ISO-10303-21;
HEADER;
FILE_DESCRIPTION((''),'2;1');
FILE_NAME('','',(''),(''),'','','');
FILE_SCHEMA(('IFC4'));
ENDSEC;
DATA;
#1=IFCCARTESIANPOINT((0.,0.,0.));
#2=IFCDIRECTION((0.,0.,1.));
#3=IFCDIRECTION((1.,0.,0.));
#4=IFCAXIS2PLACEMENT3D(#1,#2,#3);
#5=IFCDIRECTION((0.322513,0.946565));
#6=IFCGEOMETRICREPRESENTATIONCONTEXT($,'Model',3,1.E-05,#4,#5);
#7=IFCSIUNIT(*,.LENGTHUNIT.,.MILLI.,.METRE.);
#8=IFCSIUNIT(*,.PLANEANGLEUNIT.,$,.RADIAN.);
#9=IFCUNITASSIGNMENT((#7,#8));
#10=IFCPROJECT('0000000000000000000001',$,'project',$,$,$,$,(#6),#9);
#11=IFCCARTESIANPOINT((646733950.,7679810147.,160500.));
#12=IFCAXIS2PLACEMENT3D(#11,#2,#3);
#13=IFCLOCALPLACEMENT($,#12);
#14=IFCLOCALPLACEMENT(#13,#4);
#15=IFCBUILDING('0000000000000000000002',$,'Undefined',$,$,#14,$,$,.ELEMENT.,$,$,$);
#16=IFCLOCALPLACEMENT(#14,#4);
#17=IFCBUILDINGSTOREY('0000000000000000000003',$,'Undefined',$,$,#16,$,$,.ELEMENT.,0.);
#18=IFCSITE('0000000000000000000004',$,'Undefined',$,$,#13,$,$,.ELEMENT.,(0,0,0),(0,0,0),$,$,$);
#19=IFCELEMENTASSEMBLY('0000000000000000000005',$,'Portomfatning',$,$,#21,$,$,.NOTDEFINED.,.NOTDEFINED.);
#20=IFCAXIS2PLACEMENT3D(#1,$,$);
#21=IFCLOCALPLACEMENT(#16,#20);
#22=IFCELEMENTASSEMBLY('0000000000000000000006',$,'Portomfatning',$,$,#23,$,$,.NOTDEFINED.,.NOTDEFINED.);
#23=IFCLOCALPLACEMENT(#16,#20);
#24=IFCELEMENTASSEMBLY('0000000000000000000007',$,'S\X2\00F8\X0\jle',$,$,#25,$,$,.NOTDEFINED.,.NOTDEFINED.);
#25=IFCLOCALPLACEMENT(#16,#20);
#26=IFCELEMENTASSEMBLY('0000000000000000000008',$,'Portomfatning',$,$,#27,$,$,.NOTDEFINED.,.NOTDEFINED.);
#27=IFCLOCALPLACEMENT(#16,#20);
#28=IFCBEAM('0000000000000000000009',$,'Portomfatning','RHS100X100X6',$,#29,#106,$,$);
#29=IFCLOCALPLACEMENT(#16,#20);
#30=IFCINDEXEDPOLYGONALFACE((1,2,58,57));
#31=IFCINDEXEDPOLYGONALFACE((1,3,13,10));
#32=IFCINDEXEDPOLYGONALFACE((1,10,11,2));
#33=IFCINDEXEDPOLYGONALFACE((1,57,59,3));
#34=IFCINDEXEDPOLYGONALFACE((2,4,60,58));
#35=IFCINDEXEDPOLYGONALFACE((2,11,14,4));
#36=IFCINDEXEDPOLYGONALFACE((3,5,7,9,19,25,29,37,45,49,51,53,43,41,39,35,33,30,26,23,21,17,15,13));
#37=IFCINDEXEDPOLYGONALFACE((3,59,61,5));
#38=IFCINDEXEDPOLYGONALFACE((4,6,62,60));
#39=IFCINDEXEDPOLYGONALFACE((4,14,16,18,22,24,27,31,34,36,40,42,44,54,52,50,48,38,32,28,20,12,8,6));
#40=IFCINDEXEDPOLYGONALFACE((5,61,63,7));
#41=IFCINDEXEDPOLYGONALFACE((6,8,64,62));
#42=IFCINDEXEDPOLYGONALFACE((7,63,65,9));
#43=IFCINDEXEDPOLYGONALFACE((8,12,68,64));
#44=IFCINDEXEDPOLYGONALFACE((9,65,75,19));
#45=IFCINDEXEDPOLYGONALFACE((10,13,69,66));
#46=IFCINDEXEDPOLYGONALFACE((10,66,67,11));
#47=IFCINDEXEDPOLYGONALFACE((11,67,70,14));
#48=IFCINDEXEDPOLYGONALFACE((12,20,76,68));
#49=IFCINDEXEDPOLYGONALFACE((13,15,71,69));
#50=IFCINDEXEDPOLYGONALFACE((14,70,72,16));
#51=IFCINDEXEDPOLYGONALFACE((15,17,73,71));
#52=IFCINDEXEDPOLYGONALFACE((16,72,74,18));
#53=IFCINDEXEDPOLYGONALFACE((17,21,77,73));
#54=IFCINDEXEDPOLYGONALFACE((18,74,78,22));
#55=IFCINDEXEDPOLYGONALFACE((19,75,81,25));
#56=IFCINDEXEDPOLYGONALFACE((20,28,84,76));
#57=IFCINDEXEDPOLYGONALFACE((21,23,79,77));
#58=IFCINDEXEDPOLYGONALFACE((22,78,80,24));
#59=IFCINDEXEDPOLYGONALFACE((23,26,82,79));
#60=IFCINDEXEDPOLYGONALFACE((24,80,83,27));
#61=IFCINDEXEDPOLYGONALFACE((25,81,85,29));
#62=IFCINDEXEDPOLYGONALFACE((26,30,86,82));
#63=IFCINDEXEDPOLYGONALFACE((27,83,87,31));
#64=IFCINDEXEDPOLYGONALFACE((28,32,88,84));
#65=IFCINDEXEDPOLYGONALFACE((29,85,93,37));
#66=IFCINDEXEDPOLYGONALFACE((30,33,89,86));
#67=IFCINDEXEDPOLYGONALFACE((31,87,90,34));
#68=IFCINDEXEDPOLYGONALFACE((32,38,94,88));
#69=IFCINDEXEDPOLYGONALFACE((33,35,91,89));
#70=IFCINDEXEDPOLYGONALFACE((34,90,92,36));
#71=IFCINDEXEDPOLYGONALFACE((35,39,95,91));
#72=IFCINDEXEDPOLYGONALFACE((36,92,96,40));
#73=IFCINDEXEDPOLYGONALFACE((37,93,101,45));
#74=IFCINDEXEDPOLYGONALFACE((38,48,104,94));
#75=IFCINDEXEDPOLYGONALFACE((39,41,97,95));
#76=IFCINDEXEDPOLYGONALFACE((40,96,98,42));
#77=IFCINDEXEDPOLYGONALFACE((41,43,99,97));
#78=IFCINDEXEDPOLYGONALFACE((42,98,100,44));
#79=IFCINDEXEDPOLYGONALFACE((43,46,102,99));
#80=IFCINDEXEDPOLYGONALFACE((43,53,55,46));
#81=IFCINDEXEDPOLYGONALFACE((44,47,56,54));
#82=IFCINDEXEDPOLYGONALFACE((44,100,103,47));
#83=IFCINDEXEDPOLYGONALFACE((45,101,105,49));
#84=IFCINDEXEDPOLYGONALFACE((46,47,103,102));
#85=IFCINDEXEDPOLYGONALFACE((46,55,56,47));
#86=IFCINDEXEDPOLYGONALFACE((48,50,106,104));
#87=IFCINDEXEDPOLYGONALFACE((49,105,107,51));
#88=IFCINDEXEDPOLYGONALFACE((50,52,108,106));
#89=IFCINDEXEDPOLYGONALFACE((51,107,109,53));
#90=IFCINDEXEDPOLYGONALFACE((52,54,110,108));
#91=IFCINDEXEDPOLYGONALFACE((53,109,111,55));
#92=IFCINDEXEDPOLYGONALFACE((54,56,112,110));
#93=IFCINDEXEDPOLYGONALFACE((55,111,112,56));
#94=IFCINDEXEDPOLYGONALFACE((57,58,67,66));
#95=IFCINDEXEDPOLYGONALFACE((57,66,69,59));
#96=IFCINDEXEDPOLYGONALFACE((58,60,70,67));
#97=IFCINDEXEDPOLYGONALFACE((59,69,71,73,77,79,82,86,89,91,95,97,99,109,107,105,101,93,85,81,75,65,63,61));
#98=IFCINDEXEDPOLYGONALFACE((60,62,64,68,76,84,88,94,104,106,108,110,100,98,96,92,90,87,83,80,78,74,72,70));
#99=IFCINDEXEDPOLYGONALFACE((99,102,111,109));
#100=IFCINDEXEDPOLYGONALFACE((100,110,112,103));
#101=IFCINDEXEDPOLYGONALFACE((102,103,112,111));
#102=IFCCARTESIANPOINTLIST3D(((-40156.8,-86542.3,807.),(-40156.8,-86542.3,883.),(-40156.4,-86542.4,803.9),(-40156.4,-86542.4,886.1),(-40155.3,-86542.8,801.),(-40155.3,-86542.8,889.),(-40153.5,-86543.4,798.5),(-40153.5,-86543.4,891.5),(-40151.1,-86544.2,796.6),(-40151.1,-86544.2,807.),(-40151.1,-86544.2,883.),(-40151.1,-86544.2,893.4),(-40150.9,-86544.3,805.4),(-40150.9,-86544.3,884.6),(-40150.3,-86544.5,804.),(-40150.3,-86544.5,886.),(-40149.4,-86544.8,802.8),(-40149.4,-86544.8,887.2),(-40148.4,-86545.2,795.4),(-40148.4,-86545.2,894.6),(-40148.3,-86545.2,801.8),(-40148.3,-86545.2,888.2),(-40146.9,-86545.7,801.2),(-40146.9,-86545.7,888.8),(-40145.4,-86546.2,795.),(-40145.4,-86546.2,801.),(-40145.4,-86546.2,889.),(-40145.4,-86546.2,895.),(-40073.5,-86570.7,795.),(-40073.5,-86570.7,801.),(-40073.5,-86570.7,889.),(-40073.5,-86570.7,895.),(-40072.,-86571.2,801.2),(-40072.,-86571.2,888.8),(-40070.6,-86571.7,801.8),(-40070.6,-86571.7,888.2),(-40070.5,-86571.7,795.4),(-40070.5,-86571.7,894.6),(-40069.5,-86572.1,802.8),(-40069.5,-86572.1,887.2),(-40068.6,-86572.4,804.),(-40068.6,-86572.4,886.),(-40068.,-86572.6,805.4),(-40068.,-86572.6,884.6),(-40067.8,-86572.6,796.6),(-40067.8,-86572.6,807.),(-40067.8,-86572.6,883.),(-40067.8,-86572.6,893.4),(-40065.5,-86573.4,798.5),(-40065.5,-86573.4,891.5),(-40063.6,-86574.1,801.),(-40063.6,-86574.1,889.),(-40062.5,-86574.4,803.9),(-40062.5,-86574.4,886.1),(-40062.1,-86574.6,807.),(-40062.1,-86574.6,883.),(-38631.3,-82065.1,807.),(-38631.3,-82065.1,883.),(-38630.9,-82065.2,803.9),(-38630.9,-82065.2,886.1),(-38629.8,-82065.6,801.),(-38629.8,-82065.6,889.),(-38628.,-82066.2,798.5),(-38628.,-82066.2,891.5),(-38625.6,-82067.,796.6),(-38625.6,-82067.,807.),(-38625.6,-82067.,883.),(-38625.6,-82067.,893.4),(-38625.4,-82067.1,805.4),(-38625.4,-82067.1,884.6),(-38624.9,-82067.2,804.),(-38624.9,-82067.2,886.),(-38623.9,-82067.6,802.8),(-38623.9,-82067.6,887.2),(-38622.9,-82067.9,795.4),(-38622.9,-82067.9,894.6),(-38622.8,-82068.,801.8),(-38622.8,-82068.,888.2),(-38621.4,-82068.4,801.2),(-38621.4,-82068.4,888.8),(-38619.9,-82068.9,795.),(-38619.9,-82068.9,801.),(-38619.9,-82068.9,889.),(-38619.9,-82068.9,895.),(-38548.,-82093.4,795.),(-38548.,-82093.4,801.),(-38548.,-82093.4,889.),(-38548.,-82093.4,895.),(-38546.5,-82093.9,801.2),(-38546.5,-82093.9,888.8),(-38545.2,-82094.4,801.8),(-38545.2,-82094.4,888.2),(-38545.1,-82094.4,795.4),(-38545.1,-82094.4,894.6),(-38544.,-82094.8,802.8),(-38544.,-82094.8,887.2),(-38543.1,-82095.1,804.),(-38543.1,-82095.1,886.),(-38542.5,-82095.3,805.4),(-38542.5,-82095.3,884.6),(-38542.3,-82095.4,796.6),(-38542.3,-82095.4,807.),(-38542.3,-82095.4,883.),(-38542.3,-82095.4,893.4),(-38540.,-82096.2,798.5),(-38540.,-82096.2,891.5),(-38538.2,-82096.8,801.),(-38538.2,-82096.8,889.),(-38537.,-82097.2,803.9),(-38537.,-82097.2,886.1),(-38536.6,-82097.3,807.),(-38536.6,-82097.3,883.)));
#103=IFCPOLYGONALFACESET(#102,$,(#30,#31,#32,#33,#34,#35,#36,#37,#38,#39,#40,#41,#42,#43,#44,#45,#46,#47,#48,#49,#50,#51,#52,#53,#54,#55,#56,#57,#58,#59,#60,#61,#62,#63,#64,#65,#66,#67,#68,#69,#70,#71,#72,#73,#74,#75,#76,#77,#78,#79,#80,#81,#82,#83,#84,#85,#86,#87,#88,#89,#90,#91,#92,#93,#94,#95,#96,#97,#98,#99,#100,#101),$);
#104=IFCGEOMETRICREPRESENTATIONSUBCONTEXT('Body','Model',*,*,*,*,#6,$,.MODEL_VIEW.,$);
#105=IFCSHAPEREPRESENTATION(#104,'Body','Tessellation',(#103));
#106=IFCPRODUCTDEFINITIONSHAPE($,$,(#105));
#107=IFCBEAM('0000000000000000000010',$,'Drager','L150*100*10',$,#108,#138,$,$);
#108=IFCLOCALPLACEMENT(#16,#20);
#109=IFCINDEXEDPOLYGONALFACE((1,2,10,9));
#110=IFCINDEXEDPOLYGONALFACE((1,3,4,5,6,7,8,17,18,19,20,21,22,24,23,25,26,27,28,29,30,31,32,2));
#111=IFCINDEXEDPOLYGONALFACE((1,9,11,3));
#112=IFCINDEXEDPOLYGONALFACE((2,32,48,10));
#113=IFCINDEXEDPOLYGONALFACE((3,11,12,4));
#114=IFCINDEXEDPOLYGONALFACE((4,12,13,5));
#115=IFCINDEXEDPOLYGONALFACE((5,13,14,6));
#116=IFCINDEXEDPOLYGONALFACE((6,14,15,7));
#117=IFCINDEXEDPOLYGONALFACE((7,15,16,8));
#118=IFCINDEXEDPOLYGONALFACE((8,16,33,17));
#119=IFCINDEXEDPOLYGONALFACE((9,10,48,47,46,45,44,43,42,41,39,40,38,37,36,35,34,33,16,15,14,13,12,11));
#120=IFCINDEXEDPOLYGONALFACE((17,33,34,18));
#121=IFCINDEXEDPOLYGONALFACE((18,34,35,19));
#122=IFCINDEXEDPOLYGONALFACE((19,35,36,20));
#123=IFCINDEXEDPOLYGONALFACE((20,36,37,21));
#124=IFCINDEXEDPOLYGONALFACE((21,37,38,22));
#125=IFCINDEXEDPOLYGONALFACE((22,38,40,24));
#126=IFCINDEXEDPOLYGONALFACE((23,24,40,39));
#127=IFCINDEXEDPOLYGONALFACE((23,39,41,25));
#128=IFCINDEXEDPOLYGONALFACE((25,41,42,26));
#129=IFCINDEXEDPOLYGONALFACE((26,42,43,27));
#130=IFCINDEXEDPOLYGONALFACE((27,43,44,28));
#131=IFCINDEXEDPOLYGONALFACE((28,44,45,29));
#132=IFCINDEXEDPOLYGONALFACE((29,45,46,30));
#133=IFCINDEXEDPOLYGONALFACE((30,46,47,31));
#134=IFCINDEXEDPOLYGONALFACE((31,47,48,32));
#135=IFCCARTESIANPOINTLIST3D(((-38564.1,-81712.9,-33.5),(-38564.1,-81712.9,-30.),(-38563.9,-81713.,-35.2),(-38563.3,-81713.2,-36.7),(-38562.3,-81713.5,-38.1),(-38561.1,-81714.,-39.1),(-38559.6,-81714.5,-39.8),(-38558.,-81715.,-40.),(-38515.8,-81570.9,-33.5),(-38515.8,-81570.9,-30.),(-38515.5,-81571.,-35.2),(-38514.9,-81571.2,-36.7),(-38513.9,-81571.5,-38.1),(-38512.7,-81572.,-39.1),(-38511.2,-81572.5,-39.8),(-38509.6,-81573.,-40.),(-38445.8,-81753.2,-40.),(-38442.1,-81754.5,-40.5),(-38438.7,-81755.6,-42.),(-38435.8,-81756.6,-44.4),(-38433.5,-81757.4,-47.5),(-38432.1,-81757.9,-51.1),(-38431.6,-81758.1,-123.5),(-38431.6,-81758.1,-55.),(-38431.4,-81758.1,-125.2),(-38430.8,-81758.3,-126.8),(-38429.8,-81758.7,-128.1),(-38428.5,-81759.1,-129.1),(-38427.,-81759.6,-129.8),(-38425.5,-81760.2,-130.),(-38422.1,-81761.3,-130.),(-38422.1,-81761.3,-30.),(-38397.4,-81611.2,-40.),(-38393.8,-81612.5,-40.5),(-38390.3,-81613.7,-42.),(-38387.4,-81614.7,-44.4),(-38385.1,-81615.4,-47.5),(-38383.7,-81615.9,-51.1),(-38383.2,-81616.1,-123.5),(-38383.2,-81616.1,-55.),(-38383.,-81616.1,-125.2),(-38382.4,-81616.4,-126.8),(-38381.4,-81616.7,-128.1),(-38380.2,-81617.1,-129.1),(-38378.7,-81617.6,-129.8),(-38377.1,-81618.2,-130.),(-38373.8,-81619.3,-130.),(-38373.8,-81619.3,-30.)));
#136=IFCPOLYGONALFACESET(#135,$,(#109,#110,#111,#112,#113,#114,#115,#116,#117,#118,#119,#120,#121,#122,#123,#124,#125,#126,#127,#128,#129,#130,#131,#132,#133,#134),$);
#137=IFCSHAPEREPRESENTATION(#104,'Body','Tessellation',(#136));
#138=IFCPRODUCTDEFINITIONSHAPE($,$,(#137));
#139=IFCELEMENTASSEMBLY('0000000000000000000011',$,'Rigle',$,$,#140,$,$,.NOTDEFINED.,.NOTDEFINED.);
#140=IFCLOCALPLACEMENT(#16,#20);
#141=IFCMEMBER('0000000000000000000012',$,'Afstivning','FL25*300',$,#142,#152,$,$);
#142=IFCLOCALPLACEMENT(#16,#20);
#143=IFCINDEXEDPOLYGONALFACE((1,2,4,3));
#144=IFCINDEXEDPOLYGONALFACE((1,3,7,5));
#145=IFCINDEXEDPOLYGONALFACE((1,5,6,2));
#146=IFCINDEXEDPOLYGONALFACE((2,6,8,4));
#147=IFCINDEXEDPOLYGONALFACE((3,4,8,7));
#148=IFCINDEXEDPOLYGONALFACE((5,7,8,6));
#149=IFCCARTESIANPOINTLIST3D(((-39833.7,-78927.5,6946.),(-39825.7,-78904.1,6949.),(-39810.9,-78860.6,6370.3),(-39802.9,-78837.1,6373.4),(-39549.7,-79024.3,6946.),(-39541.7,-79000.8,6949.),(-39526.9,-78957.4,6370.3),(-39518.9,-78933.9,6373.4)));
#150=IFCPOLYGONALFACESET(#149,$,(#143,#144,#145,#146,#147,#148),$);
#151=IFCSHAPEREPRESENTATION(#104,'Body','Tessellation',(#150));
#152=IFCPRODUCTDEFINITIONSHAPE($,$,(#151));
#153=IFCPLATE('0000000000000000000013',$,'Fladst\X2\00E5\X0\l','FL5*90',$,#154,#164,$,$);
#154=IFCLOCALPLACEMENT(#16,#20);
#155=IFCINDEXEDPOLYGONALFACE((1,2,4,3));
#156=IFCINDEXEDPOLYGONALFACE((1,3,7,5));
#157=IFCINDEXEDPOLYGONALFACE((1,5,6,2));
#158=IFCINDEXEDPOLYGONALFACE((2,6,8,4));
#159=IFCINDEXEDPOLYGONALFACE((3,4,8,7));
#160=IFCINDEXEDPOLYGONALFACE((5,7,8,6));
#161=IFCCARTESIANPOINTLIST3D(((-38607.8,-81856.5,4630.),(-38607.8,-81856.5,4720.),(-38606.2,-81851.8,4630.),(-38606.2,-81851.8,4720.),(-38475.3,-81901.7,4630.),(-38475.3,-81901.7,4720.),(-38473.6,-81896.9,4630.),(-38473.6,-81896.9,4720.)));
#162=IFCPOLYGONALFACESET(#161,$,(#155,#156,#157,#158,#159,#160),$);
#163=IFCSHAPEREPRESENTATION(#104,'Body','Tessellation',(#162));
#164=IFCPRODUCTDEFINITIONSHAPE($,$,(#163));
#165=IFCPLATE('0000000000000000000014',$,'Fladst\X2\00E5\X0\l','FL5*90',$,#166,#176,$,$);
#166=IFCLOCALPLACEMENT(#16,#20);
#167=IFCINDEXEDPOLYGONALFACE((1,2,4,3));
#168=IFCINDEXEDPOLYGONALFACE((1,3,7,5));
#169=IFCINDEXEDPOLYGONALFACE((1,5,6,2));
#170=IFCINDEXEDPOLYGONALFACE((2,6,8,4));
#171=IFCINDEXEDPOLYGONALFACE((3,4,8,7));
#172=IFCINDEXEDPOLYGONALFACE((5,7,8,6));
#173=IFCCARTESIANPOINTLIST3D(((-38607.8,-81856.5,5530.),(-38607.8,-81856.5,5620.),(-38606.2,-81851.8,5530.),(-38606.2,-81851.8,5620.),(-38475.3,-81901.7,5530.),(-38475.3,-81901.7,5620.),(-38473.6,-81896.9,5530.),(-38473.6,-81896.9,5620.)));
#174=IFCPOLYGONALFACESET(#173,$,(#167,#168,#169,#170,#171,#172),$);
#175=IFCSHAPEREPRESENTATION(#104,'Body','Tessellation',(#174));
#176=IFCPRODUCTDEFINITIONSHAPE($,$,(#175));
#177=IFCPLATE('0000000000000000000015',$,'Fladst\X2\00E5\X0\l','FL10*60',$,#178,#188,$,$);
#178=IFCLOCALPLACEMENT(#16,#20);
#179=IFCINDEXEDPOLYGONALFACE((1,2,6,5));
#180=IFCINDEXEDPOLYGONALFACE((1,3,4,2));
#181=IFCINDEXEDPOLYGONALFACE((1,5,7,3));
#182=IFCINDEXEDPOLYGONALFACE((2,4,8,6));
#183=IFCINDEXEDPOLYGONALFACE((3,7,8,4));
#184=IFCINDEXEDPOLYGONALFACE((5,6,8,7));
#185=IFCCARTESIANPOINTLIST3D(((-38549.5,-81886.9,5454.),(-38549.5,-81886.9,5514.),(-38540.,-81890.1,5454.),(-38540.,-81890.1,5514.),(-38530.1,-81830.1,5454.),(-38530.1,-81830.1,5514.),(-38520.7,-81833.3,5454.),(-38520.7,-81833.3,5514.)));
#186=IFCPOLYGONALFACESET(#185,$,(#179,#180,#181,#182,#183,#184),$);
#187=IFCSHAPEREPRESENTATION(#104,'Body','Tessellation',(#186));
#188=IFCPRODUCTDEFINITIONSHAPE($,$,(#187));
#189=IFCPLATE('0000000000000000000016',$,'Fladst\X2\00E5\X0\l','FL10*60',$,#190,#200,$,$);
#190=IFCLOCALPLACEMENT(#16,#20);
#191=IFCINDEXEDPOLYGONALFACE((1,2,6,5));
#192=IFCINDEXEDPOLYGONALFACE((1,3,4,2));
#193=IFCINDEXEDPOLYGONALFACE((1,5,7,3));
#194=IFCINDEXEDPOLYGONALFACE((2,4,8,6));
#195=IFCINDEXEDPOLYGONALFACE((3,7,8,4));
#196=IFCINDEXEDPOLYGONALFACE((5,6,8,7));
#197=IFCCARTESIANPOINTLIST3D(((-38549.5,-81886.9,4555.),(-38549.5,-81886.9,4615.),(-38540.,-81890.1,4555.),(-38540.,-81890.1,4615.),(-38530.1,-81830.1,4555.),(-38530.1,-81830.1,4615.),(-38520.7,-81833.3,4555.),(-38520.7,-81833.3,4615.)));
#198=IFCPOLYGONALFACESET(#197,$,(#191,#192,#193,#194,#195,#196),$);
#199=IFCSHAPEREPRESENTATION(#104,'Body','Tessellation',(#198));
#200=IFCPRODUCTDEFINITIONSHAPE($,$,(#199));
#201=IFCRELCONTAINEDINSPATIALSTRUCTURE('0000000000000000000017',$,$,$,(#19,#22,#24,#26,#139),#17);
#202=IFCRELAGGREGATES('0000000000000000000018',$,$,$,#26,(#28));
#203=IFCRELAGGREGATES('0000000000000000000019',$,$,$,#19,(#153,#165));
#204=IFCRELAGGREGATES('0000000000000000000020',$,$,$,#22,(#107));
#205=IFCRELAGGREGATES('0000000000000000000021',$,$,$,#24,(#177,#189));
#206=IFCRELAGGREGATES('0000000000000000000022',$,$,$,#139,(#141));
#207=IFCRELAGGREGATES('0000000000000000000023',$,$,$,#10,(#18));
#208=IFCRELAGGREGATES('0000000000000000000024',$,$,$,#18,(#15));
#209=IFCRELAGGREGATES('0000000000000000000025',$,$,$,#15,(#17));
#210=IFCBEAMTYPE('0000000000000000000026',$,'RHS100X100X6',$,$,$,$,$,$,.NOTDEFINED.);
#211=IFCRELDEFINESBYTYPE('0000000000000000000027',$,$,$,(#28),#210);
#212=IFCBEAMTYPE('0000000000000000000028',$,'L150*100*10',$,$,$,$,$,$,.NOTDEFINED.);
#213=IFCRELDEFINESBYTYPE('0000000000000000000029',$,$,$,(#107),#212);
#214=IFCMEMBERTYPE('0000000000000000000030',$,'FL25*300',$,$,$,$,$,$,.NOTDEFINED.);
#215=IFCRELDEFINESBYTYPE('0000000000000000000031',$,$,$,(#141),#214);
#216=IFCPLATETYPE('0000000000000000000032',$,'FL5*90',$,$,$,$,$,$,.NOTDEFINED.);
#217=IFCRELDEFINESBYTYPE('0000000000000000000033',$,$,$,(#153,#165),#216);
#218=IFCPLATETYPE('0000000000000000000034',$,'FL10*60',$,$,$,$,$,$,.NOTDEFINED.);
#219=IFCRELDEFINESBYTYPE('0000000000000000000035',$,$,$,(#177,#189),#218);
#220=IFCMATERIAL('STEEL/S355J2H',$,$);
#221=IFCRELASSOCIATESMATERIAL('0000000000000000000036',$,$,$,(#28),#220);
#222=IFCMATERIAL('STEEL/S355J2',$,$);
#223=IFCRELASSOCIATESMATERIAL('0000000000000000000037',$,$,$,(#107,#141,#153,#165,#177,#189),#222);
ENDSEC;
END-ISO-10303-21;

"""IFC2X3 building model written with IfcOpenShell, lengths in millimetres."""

from ifc_helpers import new_model, si_unit, direction, frame, origin_with_axes, origin_2d_with_axis, place, context, subcontext, project, spatial, polyline, rectangle, hollow_rectangle, l_section, outline, extrude, clip, halfspace, material, type_object, element, aggregate, save


model = new_model("IFC2X3")

# Units and contexts
model_context = context("Model", 3, precision=1e-05, world=origin_with_axes(), true_north=direction((0.322513, 0.946565)))
body_context = subcontext(model_context, "Body", "Model", "MODEL_VIEW")
ifc_project = project(units=[si_unit("LENGTHUNIT", "METRE", prefix="MILLI"), si_unit("PLANEANGLEUNIT", "RADIAN")], contexts=[model_context])

# Site, building, storey
site_placement = place(None, frame((646733950.0, 7679810147.0, 160500.0), z_axis=(0.0, 0.0, 1.0), x_axis=(1.0, 0.0, 0.0)))
site = spatial("IfcSite", under=ifc_project, at=site_placement, Name="Undefined", CompositionType="ELEMENT", RefLatitude=(0, 0, 0), RefLongitude=(0, 0, 0))
building_placement = place(site_placement, origin_with_axes())
building = spatial("IfcBuilding", under=site, at=building_placement, Name="Undefined", CompositionType="ELEMENT")
storey_placement = place(building_placement, origin_with_axes())
storey = spatial("IfcBuildingStorey", under=building, at=storey_placement, Name="Undefined", CompositionType="ELEMENT", Elevation=0.0)

# Element assembly
assembly_1_placement = place(storey_placement, origin_with_axes())
assembly_1 = element("IfcElementAssembly", 1, at=assembly_1_placement, inside=storey, Name="Portomfatning", AssemblyPlace="NOTDEFINED", PredefinedType="NOTDEFINED")
ifc_material_1 = material(Name="STEEL/S355J2H")

# Element assemblies
assembly_2_placement = place(storey_placement, origin_with_axes())
assembly_2 = element("IfcElementAssembly", 2, at=assembly_2_placement, inside=storey, Name="Portomfatning", AssemblyPlace="NOTDEFINED", PredefinedType="NOTDEFINED")
assembly_3_placement = place(storey_placement, origin_with_axes())
assembly_3 = element("IfcElementAssembly", 3, at=assembly_3_placement, inside=storey, Name="Søjle", AssemblyPlace="NOTDEFINED", PredefinedType="NOTDEFINED")

# Element assembly, beam
beam_type_1 = type_object("IfcBeamType", Name="RHS100X100X6", PredefinedType="NOTDEFINED")
assembly_4_placement = place(storey_placement, origin_with_axes())
assembly_4 = element("IfcElementAssembly", 4, at=assembly_4_placement, inside=storey, Name="Portomfatning", AssemblyPlace="NOTDEFINED", PredefinedType="NOTDEFINED")
beam_1_placement = place(assembly_4_placement, frame((-38579.1, -82067.0, 845.0), z_axis=(0.946565, -0.322513, 0.0), x_axis=(-0.322513, -0.946565, 0.0)))
beam_1 = element("IfcBeam", 5, at=beam_1_placement, type_object=beam_type_1, material=ifc_material_1, Name="Portomfatning", Description="RHS100X100X6", context=body_context, shape_type="Clipping", body=[
    clip(clip(extrude(hollow_rectangle(XDim=100.0, YDim=100.0, WallThickness=6.0, InnerFilletRadius=6.0, OuterFilletRadius=12.0, at=origin_2d_with_axis()), frame((4806.7, 0.0, 0.0), z_axis=(-1.0, 0.0, 0.0), x_axis=(0.0, -1.0, 0.0)), (0.0, 0.0, 1.0), 4853.4), halfspace(frame((4745.0, -50.0, -50.0), z_axis=(-1.0, 0.0, 0.000185), x_axis=(0.0, 1.0, 0.0)), True)), halfspace(frame((15.0, 50.0, -50.0), z_axis=(1.0, 0.0, 0.000185), x_axis=(0.0, -1.0, 0.0)), True)),
])
aggregate(assembly_4, [beam_1])

# Beam
ifc_material_2 = material(Name="STEEL/S355J2")
beam_type_2 = type_object("IfcBeamType", Name="L150*100*10", PredefinedType="NOTDEFINED")
beam_2_placement = place(assembly_2_placement, frame((-38444.8, -81595.1, -80.0), z_axis=(-0.946565, 0.322513, 0.0), x_axis=(-0.322513, -0.946565, 0.0)))
beam_2 = element("IfcBeam", 6, at=beam_2_placement, type_object=beam_type_2, material=ifc_material_2, Name="Drager", Description="L150*100*10", context=body_context, shape_type="SweptSolid", body=[
    extrude(l_section(Depth=150.0, Width=100.0, Thickness=10.0, FilletRadius=15.0, EdgeRadius=6.5, at=origin_2d_with_axis()), frame((150.0, 0.0, 0.0), z_axis=(-1.0, 0.0, 0.0), x_axis=(0.0, -1.0, 0.0)), (0.0, 0.0, 1.0), 150.0),
])

# Element assembly, member
assembly_5_placement = place(storey_placement, origin_with_axes())
assembly_5 = element("IfcElementAssembly", 7, at=assembly_5_placement, inside=storey, Name="Rigle", AssemblyPlace="NOTDEFINED", PredefinedType="NOTDEFINED")
member_type = type_object("IfcMemberType", Name="FL25*300", PredefinedType="NOTDEFINED")
member_placement = place(assembly_5_placement, frame((-39687.7, -78964.2, 6947.5), z_axis=(0.946565, -0.322513, 0.0), x_axis=(0.039304, 0.115357, -0.992546)))
member = element("IfcMember", 8, at=member_placement, type_object=member_type, material=ifc_material_2, Name="Afstivning", Description="FL25*300", context=body_context, shape_type="SweptSolid", body=[
    extrude(rectangle(XDim=25.0, YDim=300.0, at=origin_2d_with_axis()), frame((580.0, 0.0, 0.0), z_axis=(-1.0, 0.0, 0.0), x_axis=(0.0, -1.0, 0.0)), (0.0, 0.0, 1.0), 580.0),
])

# Plates
plate_type_1 = type_object("IfcPlateType", Name="FL5*90", PredefinedType="NOTDEFINED")
plate_1_placement = place(assembly_1_placement, frame((-38474.5, -81899.3, 4720.0), z_axis=(0.322626, 0.946527, 0.0), x_axis=(0.0, 0.0, -1.0)))
plate_1 = element("IfcPlate", 9, at=plate_1_placement, type_object=plate_type_1, material=ifc_material_2, Name="Fladstål", Description="FL5*90", context=body_context, shape_type="SweptSolid", body=[
    extrude(outline(polyline([(0.0, 0.0), (90.0, 0.0), (90.0, 140.0), (0.0, 140.0), (0.0, 0.0)])), frame((0.0, 0.0, -2.5), z_axis=(0.0, 0.0, 1.0), x_axis=(1.0, 0.0, 0.0)), (0.0, 0.0, 1.0), 5.0),
])
plate_2_placement = place(assembly_1_placement, frame((-38474.5, -81899.3, 5620.0), z_axis=(0.322626, 0.946527, 0.0), x_axis=(0.0, 0.0, -1.0)))
plate_2 = element("IfcPlate", 10, at=plate_2_placement, type_object=plate_type_1, material=ifc_material_2, Name="Fladstål", Description="FL5*90", context=body_context, shape_type="SweptSolid", body=[
    extrude(outline(polyline([(0.0, 0.0), (90.0, 0.0), (90.0, 140.0), (0.0, 140.0), (0.0, 0.0)])), frame((0.0, 0.0, -2.5), z_axis=(0.0, 0.0, 1.0), x_axis=(1.0, 0.0, 0.0)), (0.0, 0.0, 1.0), 5.0),
])
aggregate(assembly_1, [plate_1, plate_2])
plate_type_2 = type_object("IfcPlateType", Name="FL10*60", PredefinedType="NOTDEFINED")
plate_3_placement = place(assembly_3_placement, frame((-38544.7, -81888.5, 5514.0), z_axis=(-0.946565, 0.322513, 0.0), x_axis=(0.322513, 0.946565, 0.0)))
plate_3 = element("IfcPlate", 11, at=plate_3_placement, type_object=plate_type_2, material=ifc_material_2, Name="Fladstål", Description="FL10*60", context=body_context, shape_type="SweptSolid", body=[
    extrude(outline(polyline([(0.0, 0.0), (60.0, 0.0), (60.0, 60.0), (0.0, 60.0), (0.0, 0.0)])), frame((0.0, 0.0, -5.0), z_axis=(0.0, 0.0, 1.0), x_axis=(1.0, 0.0, 0.0)), (0.0, 0.0, 1.0), 10.0),
])
plate_4_placement = place(assembly_3_placement, frame((-38544.7, -81888.5, 4615.0), z_axis=(-0.946565, 0.322513, 0.0), x_axis=(0.322513, 0.946565, 0.0)))
plate_4 = element("IfcPlate", 12, at=plate_4_placement, type_object=plate_type_2, material=ifc_material_2, Name="Fladstål", Description="FL10*60", context=body_context, shape_type="SweptSolid", body=[
    extrude(outline(polyline([(0.0, 0.0), (60.0, 0.0), (60.0, 60.0), (0.0, 60.0), (0.0, 0.0)])), frame((0.0, 0.0, -5.0), z_axis=(0.0, 0.0, 1.0), x_axis=(1.0, 0.0, 0.0)), (0.0, 0.0, 1.0), 10.0),
])

aggregate(assembly_2, [beam_2])
aggregate(assembly_3, [plate_3, plate_4])
aggregate(assembly_5, [member])

save(model, "model.ifc")
